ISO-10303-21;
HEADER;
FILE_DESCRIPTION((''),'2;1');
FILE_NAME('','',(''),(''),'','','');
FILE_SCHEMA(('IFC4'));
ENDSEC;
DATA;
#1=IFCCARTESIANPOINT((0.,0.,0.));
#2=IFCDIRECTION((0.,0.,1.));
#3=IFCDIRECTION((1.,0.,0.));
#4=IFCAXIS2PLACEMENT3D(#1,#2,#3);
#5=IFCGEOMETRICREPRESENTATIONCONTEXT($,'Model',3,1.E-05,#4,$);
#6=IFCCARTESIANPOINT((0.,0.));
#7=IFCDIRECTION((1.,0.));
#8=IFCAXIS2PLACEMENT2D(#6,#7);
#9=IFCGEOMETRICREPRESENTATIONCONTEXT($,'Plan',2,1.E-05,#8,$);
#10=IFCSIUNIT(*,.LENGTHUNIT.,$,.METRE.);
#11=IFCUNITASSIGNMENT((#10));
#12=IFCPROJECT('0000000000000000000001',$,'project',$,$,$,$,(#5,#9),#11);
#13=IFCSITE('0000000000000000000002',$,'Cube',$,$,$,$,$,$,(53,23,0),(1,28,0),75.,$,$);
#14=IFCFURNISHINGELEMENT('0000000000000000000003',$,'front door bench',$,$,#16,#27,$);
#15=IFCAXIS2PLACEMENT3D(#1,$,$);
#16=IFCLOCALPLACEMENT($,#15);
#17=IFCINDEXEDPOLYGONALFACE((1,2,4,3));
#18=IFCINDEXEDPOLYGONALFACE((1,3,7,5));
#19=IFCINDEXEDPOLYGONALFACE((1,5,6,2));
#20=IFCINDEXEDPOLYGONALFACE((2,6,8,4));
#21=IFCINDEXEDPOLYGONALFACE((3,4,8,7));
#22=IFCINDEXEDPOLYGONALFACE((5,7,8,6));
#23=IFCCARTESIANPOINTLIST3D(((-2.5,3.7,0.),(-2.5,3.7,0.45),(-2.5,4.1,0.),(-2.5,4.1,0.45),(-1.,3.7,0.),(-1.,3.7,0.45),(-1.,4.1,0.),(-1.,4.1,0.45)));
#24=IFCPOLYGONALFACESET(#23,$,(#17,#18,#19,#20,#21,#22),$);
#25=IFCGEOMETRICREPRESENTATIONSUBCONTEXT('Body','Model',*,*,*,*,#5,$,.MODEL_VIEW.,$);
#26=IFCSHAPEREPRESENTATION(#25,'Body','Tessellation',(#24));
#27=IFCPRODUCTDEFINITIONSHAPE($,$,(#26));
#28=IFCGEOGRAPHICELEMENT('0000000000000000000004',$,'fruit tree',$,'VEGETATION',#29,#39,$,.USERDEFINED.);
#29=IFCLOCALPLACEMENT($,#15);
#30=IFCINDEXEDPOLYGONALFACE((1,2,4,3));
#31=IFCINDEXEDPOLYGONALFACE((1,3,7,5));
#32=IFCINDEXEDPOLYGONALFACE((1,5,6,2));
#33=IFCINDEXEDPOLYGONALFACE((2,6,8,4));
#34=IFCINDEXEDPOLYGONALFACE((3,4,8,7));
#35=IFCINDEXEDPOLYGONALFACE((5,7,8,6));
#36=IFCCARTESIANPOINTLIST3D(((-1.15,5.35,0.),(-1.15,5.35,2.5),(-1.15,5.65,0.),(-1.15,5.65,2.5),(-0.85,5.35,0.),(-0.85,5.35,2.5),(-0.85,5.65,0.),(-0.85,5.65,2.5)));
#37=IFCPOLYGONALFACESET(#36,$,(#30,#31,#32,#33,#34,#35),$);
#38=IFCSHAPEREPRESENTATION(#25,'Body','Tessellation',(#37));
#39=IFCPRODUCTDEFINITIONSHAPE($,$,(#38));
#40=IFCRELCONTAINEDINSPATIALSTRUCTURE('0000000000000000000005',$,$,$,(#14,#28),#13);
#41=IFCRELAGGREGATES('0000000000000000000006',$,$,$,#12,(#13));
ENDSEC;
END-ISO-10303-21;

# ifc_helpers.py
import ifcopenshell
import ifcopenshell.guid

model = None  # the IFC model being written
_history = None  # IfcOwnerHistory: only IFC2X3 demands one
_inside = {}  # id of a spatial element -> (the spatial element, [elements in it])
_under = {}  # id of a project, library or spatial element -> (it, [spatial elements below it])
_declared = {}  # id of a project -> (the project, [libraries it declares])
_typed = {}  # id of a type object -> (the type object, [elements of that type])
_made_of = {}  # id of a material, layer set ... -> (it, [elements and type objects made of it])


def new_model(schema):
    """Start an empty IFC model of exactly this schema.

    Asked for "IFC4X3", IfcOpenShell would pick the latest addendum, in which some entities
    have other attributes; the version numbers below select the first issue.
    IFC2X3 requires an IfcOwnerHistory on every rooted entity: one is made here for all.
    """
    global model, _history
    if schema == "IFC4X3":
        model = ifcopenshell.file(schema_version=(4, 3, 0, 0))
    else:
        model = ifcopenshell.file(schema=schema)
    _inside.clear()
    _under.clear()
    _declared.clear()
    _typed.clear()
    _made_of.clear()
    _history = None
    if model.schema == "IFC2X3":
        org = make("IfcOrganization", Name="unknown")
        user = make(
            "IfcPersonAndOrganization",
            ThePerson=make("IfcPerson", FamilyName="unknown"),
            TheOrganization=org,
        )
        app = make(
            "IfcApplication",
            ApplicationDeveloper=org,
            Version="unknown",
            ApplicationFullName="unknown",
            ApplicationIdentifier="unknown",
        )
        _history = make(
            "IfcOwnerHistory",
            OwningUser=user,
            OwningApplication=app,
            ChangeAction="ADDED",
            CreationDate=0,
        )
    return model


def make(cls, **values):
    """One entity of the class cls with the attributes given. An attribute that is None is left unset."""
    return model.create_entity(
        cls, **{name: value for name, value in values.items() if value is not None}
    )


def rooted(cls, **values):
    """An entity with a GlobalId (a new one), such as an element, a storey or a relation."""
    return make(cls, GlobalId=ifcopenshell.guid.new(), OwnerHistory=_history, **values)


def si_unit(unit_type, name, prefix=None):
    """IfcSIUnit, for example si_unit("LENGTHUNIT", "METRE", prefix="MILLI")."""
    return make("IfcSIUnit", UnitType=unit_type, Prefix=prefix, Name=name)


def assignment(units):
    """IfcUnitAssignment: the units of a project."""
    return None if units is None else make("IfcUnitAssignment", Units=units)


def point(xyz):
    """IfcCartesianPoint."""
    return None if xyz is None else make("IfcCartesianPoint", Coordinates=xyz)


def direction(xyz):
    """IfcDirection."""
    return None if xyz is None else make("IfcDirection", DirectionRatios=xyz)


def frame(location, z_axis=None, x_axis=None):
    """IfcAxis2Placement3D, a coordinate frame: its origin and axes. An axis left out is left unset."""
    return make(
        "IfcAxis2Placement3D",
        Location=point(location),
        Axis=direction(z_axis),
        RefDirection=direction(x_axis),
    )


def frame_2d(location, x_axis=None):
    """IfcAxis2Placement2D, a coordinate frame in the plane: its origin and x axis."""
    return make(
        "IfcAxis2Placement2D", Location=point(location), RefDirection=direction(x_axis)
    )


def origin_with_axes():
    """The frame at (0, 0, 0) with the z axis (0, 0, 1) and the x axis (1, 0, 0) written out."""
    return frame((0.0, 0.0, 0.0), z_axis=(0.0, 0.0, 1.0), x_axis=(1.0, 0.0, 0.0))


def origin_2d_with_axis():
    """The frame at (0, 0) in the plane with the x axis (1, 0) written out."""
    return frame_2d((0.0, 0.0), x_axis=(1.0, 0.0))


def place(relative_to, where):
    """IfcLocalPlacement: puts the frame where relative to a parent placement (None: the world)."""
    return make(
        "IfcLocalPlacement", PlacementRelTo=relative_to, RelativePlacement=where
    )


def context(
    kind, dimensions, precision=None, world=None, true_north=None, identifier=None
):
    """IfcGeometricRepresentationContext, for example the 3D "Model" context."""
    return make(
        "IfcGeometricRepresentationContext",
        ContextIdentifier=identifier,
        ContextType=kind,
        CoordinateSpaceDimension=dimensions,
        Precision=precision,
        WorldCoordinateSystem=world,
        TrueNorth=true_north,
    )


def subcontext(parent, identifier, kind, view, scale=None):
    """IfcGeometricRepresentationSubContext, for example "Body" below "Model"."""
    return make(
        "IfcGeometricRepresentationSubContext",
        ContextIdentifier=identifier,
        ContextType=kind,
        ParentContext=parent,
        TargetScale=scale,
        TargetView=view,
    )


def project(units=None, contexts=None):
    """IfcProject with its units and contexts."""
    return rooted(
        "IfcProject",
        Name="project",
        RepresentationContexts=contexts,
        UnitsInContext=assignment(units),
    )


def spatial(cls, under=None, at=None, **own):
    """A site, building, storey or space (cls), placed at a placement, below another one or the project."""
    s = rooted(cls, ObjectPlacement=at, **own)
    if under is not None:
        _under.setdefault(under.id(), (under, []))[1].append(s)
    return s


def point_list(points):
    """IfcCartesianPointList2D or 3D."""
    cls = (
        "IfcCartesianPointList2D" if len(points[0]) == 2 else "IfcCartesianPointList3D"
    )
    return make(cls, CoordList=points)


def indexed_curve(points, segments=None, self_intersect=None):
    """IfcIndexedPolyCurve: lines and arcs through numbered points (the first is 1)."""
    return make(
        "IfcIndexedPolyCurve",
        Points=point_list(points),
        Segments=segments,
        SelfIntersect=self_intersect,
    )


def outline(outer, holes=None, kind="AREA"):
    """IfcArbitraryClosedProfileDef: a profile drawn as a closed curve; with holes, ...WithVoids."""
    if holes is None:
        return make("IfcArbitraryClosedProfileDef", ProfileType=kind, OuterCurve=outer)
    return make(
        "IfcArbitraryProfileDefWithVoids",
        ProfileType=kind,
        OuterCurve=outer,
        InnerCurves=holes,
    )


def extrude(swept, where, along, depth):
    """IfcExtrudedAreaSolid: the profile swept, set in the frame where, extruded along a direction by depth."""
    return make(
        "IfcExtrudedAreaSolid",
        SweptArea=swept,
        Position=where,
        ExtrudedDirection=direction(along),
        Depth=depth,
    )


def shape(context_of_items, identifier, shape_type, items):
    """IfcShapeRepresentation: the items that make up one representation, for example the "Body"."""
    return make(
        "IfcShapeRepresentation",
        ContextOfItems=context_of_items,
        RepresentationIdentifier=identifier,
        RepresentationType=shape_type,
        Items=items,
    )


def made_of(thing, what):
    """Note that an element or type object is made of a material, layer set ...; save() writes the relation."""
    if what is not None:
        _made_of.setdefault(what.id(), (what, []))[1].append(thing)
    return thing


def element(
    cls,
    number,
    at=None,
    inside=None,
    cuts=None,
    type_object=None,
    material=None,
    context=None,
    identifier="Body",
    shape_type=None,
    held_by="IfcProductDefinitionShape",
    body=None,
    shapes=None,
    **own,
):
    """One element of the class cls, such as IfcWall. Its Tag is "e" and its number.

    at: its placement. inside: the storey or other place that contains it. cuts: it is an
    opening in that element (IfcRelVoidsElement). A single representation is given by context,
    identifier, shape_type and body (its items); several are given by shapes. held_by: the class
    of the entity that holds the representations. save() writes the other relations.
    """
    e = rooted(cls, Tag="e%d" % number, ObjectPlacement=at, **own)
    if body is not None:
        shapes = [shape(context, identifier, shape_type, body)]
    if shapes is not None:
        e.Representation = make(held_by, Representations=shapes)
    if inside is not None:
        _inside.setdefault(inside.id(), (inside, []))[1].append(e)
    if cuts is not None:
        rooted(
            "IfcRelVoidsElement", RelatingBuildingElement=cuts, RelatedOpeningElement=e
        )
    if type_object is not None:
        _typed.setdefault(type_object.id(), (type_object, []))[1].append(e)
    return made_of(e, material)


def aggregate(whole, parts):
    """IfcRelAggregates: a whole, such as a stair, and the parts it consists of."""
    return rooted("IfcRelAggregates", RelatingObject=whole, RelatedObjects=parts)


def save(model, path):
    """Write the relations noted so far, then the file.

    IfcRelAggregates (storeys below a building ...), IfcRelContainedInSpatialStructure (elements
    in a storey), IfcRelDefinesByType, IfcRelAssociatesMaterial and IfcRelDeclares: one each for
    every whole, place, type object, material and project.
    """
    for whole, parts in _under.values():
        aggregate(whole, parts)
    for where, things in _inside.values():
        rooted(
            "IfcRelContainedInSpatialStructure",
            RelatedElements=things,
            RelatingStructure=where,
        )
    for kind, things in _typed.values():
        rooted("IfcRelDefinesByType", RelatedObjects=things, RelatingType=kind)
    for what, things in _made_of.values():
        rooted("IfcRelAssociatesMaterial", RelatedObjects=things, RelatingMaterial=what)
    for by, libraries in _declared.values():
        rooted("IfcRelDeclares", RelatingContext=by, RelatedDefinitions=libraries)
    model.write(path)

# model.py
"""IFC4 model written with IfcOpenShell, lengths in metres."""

from ifc_helpers import new_model, si_unit, frame, origin_with_axes, origin_2d_with_axis, place, context, subcontext, project, spatial, indexed_curve, outline, extrude, element, save


model = new_model("IFC4")

# Units and contexts
model_context = context("Model", 3, precision=1e-05, world=origin_with_axes())
plan_context = context("Plan", 2, precision=1e-05, world=origin_2d_with_axis())
body_context = subcontext(model_context, "Body", "Model", "MODEL_VIEW")
ifc_project = project(units=[si_unit("LENGTHUNIT", "METRE")], contexts=[model_context, plan_context])

# Site
site = spatial("IfcSite", under=ifc_project, Name="Cube", RefLatitude=(53, 23, 0), RefLongitude=(1, 28, 0), RefElevation=75.0)

# Furnishing element
furnishing_placement = place(None, frame((-2.5, 3.7, 0.0), z_axis=(0.0, 0.0, 1.0), x_axis=(1.0, 0.0, 0.0)))
element("IfcFurnishingElement", 1, at=furnishing_placement, inside=site, Name="front door bench", context=body_context, shape_type="SweptSolid", body=[
    extrude(outline(indexed_curve([(0.0, 0.0), (1.5, 0.0), (1.5, 0.4), (0.0, 0.4)])), None, (0.0, 0.0, 1.0), 0.45),
])

# Geographic element
geographic_element_placement = place(None, frame((-1.0, 5.5, 0.0), z_axis=(0.0, 0.0, 1.0), x_axis=(1.0, 0.0, 0.0)))
element("IfcGeographicElement", 2, at=geographic_element_placement, inside=site, Name="fruit tree", ObjectType="VEGETATION", PredefinedType="USERDEFINED", context=body_context, shape_type="SweptSolid", body=[
    extrude(outline(indexed_curve([(-0.15, -0.15), (0.15, -0.15), (0.15, 0.15), (-0.15, 0.15)])), None, (0.0, 0.0, 1.0), 2.5),
])

save(model, "model.ifc")
